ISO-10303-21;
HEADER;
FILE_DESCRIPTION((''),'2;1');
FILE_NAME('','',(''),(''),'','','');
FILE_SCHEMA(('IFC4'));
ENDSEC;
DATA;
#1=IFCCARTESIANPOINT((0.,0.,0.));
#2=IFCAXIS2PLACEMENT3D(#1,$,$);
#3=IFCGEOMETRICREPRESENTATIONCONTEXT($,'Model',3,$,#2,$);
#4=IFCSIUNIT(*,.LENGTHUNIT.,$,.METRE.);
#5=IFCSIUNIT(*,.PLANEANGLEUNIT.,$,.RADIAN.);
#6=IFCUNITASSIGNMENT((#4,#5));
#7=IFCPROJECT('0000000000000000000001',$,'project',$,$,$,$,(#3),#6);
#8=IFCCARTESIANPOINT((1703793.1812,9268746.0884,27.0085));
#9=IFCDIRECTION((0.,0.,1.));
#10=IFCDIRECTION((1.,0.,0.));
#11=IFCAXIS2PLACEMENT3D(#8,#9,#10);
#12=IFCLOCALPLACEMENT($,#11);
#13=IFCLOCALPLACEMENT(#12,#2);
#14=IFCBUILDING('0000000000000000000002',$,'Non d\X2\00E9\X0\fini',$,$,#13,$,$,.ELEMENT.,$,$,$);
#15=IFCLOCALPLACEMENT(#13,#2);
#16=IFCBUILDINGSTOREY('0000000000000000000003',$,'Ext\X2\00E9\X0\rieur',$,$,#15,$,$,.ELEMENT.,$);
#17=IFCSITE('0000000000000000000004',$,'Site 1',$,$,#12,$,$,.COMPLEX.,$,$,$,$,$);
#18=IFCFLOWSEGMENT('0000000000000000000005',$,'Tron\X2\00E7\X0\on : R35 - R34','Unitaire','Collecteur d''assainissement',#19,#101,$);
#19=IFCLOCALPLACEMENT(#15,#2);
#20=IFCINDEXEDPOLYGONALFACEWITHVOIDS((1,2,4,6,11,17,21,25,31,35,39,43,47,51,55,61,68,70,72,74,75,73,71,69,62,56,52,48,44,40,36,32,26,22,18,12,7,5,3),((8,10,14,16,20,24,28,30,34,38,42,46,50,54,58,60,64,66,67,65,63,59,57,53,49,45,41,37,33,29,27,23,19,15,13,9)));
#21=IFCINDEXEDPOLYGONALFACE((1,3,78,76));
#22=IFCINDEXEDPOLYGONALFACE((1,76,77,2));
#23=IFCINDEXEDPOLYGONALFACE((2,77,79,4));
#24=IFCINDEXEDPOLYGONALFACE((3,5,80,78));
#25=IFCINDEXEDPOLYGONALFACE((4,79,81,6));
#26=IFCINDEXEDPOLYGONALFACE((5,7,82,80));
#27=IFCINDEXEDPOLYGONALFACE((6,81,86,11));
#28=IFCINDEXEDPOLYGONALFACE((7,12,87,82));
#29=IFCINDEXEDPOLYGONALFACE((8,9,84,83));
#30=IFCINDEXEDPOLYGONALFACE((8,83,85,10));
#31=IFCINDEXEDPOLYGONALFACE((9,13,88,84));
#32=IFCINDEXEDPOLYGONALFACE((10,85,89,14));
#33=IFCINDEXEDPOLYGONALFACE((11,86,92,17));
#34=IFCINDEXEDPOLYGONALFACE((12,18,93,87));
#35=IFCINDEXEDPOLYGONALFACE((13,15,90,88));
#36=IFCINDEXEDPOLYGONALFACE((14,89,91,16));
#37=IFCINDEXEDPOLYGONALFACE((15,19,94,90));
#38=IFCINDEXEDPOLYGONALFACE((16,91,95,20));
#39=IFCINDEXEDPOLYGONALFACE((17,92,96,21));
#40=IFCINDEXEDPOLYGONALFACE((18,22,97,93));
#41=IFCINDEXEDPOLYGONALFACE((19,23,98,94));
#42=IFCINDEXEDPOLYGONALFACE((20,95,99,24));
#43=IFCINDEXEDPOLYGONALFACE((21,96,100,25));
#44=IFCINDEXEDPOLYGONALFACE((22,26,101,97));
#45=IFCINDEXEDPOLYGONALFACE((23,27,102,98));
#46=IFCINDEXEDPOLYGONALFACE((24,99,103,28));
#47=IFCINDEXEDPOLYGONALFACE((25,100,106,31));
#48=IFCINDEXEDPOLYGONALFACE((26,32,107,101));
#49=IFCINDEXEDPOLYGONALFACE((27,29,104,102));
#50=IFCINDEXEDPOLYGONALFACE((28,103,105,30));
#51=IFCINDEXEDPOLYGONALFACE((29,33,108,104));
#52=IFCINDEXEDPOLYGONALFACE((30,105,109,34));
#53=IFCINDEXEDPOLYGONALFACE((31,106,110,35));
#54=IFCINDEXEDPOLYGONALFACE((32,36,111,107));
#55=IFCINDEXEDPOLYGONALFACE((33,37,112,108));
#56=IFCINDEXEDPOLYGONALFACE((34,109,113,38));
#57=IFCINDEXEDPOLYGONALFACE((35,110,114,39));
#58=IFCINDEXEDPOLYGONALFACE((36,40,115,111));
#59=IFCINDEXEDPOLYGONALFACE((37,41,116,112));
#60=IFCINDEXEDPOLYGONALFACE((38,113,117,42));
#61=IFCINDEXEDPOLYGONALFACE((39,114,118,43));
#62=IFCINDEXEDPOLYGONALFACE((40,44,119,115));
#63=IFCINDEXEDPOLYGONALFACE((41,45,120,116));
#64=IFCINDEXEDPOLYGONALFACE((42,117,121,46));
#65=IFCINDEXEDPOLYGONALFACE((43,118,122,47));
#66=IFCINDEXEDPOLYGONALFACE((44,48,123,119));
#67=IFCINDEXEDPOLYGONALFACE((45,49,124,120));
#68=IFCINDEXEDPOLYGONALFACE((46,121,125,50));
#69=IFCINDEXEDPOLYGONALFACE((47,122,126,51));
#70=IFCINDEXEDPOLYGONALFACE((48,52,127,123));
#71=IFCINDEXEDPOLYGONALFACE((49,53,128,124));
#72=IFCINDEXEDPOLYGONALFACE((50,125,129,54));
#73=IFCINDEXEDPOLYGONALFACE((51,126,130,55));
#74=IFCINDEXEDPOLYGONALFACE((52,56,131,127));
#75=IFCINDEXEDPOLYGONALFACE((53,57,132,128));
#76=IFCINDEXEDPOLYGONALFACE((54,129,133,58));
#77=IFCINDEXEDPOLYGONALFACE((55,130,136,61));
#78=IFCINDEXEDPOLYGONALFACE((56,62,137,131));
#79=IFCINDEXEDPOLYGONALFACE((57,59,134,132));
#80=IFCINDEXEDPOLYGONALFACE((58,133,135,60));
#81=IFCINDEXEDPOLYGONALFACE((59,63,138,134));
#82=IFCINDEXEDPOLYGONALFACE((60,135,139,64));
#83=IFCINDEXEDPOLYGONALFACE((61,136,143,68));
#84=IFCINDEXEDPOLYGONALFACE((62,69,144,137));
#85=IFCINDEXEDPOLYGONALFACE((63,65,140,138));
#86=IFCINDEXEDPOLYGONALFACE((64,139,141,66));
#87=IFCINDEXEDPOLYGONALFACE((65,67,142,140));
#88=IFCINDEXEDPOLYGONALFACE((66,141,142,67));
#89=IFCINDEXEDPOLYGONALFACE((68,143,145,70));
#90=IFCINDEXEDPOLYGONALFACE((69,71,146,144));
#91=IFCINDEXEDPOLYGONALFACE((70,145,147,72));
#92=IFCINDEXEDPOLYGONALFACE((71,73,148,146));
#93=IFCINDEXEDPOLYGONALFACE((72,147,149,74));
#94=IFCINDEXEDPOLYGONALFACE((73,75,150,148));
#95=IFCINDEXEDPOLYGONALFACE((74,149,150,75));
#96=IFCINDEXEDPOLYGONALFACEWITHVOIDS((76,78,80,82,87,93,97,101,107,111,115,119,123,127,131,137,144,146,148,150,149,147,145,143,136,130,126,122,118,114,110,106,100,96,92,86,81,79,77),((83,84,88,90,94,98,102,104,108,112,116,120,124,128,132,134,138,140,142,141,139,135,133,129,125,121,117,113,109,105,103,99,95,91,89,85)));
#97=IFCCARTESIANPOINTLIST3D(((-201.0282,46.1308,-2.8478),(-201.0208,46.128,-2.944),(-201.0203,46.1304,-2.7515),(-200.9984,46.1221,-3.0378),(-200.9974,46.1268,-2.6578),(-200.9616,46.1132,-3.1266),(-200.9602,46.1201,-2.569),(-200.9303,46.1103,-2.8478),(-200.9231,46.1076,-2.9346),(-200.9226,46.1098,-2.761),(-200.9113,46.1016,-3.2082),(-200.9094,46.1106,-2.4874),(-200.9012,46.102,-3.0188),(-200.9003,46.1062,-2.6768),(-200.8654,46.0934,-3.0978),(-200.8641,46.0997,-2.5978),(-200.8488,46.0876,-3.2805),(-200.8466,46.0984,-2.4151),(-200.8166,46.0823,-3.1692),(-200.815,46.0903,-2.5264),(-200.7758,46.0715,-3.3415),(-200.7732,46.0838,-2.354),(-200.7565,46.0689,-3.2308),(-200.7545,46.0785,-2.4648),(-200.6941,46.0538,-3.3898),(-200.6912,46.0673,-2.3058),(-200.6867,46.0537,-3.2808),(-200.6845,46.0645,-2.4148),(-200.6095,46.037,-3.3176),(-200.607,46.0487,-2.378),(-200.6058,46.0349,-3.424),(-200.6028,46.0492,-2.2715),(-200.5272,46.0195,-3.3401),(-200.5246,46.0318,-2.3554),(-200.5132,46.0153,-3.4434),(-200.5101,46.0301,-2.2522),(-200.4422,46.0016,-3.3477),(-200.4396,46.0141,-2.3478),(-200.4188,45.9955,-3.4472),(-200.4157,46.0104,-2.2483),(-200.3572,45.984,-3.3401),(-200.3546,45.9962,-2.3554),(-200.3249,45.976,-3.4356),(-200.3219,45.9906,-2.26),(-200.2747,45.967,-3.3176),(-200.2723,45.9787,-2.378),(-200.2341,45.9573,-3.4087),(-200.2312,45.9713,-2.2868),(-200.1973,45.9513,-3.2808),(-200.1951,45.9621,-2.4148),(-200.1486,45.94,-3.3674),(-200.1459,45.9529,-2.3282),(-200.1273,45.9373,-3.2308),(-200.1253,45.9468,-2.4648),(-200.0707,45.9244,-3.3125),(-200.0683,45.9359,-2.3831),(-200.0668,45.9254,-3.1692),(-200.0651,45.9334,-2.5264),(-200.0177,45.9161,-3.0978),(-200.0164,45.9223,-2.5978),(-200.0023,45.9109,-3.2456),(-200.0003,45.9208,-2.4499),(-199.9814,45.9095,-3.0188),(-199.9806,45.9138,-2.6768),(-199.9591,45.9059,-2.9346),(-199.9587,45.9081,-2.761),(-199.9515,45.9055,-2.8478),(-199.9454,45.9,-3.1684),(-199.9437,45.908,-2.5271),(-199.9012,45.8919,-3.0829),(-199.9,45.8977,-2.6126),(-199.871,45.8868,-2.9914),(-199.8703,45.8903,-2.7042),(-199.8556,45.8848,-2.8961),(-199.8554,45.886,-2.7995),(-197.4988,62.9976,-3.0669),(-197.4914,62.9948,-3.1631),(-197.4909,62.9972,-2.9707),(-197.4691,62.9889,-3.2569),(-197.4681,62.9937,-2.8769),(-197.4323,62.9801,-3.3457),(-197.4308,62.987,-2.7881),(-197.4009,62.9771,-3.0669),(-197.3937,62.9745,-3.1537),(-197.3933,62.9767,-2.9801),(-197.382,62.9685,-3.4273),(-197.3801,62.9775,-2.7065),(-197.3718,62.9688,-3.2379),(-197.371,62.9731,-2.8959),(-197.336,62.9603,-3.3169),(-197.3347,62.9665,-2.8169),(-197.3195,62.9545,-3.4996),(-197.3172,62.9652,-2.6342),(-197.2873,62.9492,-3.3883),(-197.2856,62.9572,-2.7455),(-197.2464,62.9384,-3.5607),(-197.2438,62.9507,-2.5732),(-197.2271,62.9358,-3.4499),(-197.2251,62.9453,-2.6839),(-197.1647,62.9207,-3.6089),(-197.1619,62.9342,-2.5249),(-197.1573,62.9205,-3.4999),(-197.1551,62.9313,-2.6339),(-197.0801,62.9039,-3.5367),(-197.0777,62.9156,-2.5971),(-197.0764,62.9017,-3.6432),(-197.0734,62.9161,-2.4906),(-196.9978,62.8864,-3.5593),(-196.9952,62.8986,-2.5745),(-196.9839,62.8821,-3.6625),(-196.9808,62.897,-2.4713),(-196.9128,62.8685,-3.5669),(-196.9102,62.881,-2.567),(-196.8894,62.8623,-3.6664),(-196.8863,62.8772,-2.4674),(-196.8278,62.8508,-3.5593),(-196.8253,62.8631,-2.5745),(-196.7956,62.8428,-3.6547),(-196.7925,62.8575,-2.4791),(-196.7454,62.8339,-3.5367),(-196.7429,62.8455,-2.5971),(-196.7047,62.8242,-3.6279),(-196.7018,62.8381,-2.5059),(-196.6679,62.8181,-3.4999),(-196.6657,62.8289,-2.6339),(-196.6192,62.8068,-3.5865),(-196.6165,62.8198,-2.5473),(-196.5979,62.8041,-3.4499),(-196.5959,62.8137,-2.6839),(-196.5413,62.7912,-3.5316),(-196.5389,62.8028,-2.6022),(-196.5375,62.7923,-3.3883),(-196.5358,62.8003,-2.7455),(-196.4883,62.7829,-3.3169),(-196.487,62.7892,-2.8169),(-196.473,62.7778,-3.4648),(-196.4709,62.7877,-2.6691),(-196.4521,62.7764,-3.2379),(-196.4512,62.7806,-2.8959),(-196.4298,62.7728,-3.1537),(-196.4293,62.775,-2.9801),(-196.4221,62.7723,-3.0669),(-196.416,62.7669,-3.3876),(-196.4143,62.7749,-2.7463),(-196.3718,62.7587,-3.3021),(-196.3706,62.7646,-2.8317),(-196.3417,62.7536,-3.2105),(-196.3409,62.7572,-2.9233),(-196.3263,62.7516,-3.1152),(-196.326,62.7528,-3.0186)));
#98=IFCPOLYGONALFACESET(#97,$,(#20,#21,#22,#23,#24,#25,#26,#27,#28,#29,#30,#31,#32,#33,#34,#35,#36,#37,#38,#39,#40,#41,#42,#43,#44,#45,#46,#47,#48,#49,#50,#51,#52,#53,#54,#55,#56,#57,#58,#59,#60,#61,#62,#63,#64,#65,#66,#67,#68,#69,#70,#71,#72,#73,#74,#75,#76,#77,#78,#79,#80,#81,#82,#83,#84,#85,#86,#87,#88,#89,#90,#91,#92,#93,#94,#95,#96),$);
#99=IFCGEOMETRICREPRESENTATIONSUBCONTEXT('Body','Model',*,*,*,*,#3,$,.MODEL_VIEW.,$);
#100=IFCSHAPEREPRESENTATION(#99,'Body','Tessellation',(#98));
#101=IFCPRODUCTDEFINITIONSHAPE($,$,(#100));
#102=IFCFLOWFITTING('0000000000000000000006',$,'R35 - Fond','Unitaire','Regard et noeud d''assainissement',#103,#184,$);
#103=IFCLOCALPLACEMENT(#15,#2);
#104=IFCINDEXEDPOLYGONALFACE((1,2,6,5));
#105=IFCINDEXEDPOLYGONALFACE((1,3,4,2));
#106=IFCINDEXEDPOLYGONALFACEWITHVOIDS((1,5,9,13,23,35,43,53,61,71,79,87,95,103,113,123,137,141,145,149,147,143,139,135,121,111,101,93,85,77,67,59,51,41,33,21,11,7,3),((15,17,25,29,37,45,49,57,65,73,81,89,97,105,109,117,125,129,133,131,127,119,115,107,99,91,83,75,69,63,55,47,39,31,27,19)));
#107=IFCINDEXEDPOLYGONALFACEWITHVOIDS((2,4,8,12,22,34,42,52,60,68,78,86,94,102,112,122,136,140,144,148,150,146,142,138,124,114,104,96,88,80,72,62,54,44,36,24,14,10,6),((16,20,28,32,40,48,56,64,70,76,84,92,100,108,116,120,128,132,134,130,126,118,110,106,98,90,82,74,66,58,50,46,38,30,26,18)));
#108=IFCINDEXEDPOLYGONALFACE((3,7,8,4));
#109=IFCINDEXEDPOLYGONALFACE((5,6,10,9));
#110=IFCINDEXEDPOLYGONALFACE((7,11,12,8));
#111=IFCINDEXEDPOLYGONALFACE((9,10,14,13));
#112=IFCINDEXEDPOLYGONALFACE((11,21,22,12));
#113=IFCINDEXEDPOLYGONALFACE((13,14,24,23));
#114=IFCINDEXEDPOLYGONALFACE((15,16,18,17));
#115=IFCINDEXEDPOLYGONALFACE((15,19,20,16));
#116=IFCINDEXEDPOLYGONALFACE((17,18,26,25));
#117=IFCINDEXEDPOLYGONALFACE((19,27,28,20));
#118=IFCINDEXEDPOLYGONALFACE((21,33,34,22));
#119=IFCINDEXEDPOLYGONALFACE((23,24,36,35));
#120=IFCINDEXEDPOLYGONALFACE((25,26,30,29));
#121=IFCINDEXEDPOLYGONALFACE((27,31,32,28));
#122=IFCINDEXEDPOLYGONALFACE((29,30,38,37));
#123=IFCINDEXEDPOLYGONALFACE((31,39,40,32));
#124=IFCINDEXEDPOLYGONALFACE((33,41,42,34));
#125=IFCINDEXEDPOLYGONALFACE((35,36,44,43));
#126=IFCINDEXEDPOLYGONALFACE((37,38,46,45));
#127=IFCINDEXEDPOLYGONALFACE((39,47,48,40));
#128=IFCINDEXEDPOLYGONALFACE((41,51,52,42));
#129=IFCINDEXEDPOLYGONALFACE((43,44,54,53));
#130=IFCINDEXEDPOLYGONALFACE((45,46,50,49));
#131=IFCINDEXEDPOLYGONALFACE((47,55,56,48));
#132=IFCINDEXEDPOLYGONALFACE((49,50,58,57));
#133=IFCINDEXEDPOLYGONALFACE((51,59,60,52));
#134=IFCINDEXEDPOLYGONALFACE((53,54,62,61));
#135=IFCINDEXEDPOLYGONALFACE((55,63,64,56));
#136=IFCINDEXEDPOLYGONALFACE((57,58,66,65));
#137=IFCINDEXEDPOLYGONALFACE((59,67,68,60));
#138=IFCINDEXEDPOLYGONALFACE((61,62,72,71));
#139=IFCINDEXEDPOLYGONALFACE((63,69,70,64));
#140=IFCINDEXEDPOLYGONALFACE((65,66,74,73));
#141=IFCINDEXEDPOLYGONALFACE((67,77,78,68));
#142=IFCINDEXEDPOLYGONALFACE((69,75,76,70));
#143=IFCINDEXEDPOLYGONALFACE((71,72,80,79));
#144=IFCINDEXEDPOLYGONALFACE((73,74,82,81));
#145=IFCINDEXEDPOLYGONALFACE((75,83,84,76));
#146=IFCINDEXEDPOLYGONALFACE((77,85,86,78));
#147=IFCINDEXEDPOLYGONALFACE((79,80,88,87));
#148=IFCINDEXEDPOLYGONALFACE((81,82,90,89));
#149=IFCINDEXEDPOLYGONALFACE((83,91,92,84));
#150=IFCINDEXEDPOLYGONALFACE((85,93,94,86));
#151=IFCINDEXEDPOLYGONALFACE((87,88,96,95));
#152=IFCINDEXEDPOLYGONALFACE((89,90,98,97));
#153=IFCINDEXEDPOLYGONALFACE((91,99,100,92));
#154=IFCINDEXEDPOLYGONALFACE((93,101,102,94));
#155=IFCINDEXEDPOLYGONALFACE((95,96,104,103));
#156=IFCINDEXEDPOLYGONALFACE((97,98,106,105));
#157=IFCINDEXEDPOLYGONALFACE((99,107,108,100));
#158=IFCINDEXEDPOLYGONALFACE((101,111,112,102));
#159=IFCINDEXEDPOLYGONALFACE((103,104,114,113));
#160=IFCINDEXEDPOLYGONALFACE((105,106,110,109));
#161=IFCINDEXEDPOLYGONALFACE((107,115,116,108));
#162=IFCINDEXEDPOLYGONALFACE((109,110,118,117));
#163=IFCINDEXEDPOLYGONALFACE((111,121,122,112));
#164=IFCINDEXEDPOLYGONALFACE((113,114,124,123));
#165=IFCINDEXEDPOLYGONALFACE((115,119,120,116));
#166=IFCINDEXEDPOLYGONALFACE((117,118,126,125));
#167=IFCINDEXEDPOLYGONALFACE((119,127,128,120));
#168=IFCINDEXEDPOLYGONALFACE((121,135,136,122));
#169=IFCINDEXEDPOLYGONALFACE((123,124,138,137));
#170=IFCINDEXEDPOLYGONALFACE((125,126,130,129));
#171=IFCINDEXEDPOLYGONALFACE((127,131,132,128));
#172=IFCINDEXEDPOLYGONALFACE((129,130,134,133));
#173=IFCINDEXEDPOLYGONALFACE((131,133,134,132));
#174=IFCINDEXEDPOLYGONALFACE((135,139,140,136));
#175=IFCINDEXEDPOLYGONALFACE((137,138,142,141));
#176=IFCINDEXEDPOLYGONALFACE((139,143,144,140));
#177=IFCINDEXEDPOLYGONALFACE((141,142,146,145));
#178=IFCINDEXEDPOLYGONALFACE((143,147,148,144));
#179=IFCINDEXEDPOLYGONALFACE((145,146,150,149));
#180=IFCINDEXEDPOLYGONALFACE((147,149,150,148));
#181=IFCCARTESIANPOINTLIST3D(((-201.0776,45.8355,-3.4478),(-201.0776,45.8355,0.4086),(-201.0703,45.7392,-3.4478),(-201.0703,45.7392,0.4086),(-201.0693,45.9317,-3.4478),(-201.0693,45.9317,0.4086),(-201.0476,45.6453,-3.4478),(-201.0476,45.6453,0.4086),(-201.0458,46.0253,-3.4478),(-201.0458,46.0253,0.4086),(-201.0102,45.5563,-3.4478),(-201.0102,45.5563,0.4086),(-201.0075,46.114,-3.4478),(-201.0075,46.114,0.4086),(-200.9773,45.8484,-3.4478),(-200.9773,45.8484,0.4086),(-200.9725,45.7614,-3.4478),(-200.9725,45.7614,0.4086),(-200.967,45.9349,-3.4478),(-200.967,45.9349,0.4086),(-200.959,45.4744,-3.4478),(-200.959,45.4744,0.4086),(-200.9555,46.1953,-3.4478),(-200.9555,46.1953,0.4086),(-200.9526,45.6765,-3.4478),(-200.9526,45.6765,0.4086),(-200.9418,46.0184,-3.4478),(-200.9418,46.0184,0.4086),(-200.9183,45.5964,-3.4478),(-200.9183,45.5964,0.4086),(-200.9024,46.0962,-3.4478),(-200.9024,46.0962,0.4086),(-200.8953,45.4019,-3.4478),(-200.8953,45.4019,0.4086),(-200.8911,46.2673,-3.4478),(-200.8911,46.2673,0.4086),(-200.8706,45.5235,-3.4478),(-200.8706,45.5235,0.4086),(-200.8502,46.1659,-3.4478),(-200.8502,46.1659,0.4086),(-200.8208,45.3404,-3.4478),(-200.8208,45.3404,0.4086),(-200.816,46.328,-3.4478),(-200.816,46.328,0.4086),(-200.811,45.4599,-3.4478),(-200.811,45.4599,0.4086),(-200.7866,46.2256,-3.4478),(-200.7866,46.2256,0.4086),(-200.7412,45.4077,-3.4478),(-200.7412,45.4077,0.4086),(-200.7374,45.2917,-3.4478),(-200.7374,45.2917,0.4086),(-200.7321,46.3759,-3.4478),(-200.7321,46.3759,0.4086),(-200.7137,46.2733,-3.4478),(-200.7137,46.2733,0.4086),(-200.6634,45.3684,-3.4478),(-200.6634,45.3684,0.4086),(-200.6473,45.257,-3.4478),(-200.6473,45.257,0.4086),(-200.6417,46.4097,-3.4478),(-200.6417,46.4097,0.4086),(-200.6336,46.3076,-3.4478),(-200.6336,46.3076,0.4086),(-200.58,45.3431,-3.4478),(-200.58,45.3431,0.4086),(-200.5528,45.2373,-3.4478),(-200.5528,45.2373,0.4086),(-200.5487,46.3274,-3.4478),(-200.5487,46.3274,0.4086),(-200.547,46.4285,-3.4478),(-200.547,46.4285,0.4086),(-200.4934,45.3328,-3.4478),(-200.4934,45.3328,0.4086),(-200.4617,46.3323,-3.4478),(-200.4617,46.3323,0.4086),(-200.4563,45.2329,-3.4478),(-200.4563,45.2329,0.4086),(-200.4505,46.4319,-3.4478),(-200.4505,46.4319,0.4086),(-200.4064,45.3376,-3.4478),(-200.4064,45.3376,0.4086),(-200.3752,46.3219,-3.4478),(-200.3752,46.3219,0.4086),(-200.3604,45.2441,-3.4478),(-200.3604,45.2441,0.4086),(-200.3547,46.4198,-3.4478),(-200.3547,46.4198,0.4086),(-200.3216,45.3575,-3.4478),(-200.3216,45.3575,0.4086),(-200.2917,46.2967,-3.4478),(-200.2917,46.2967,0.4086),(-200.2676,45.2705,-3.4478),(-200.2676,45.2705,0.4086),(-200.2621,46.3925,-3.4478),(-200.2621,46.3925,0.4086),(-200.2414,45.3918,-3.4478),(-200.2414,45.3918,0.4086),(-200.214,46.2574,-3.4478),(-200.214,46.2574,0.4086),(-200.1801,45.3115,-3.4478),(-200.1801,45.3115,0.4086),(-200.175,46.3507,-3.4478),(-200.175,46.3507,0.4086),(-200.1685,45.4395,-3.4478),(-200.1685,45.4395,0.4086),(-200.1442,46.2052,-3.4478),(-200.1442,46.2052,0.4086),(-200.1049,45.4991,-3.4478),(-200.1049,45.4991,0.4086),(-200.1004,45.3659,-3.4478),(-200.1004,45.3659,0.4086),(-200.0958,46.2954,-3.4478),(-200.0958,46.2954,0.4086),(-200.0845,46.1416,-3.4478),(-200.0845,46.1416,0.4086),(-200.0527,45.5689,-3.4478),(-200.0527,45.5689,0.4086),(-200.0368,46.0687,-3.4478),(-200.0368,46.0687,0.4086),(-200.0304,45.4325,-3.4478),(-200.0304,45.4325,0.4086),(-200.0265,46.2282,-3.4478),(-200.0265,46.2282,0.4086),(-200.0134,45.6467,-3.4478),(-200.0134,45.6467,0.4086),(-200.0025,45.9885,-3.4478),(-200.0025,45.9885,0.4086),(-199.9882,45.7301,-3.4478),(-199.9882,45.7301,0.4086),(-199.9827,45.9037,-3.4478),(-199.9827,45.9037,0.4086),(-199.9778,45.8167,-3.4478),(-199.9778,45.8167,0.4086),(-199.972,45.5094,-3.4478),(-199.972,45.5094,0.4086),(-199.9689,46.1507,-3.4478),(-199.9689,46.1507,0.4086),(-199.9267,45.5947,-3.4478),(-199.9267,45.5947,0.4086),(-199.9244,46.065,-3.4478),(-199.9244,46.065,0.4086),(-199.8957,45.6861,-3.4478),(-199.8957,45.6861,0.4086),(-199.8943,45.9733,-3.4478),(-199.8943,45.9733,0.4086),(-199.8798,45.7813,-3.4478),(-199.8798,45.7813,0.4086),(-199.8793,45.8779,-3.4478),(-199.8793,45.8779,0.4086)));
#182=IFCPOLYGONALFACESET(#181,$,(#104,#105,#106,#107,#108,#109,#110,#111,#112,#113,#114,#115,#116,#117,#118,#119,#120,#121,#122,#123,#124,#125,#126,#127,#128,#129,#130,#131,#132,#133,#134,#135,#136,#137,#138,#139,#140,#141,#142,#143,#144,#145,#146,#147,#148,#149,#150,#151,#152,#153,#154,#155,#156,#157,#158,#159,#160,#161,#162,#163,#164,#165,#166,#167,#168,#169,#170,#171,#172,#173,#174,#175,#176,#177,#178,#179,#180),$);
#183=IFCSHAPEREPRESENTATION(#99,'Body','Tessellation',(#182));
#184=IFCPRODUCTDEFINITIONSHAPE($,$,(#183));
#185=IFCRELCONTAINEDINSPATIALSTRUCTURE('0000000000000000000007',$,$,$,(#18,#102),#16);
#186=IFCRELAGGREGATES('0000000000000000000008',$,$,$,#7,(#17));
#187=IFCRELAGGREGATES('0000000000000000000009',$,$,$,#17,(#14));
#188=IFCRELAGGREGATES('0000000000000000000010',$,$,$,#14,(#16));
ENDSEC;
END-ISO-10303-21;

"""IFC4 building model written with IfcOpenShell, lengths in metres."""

from ifc_helpers import new_model, si_unit, frame, origin, origin_2d, place, context, subcontext, project, spatial, hollow_circle, extrude, element, save


model = new_model("IFC4")

# Units and contexts
model_context = context("Model", 3, world=origin())
body_context = subcontext(model_context, "Body", "Model", "MODEL_VIEW")
ifc_project = project(units=[si_unit("LENGTHUNIT", "METRE"), si_unit("PLANEANGLEUNIT", "RADIAN")], contexts=[model_context])

# Site, building, storey
site_placement = place(None, frame((1703793.1812, 9268746.0884, 27.0085), z_axis=(0.0, 0.0, 1.0), x_axis=(1.0, 0.0, 0.0)))
site = spatial("IfcSite", under=ifc_project, at=site_placement, Name="Site 1", CompositionType="COMPLEX")
building_placement = place(site_placement, origin())
building = spatial("IfcBuilding", under=site, at=building_placement, Name="Non défini", CompositionType="ELEMENT")
storey_placement = place(building_placement, origin())
storey = spatial("IfcBuildingStorey", under=building, at=storey_placement, Name="Extérieur", CompositionType="ELEMENT")

# Flow segment
flow_segment_1_placement = place(storey_placement, origin())
element("IfcFlowSegment", 1, at=flow_segment_1_placement, inside=storey, Name="Tronçon : R35 - R34", Description="Unitaire", ObjectType="Collecteur d'assainissement", context=body_context, shape_type="SweptSolid", body=[
    extrude(hollow_circle(Radius=0.6, WallThickness=0.1, at=origin_2d()), frame((-200.4409, 46.0079, -2.8478), z_axis=(0.204796, 0.978722, -0.012715), x_axis=(-0.978801, 0.204813, 0.0)), (0.0, 0.0, 1.0), 17.2336),
])

# Flow fitting
flow_fitting_1_placement = place(storey_placement, origin())
element("IfcFlowFitting", 2, at=flow_fitting_1_placement, inside=storey, Name="R35 - Fond", Description="Unitaire", ObjectType="Regard et noeud d'assainissement", context=body_context, shape_type="SweptSolid", body=[
    extrude(hollow_circle(Radius=0.6, WallThickness=0.1, at=origin_2d()), frame((-200.4776, 45.8325, -3.4478), z_axis=(0.0, 0.0, 1.0), x_axis=(0.204813, 0.978801, 0.0)), (0.0, 0.0, 1.0), 3.8564),
])

save(model, "model.ifc")
